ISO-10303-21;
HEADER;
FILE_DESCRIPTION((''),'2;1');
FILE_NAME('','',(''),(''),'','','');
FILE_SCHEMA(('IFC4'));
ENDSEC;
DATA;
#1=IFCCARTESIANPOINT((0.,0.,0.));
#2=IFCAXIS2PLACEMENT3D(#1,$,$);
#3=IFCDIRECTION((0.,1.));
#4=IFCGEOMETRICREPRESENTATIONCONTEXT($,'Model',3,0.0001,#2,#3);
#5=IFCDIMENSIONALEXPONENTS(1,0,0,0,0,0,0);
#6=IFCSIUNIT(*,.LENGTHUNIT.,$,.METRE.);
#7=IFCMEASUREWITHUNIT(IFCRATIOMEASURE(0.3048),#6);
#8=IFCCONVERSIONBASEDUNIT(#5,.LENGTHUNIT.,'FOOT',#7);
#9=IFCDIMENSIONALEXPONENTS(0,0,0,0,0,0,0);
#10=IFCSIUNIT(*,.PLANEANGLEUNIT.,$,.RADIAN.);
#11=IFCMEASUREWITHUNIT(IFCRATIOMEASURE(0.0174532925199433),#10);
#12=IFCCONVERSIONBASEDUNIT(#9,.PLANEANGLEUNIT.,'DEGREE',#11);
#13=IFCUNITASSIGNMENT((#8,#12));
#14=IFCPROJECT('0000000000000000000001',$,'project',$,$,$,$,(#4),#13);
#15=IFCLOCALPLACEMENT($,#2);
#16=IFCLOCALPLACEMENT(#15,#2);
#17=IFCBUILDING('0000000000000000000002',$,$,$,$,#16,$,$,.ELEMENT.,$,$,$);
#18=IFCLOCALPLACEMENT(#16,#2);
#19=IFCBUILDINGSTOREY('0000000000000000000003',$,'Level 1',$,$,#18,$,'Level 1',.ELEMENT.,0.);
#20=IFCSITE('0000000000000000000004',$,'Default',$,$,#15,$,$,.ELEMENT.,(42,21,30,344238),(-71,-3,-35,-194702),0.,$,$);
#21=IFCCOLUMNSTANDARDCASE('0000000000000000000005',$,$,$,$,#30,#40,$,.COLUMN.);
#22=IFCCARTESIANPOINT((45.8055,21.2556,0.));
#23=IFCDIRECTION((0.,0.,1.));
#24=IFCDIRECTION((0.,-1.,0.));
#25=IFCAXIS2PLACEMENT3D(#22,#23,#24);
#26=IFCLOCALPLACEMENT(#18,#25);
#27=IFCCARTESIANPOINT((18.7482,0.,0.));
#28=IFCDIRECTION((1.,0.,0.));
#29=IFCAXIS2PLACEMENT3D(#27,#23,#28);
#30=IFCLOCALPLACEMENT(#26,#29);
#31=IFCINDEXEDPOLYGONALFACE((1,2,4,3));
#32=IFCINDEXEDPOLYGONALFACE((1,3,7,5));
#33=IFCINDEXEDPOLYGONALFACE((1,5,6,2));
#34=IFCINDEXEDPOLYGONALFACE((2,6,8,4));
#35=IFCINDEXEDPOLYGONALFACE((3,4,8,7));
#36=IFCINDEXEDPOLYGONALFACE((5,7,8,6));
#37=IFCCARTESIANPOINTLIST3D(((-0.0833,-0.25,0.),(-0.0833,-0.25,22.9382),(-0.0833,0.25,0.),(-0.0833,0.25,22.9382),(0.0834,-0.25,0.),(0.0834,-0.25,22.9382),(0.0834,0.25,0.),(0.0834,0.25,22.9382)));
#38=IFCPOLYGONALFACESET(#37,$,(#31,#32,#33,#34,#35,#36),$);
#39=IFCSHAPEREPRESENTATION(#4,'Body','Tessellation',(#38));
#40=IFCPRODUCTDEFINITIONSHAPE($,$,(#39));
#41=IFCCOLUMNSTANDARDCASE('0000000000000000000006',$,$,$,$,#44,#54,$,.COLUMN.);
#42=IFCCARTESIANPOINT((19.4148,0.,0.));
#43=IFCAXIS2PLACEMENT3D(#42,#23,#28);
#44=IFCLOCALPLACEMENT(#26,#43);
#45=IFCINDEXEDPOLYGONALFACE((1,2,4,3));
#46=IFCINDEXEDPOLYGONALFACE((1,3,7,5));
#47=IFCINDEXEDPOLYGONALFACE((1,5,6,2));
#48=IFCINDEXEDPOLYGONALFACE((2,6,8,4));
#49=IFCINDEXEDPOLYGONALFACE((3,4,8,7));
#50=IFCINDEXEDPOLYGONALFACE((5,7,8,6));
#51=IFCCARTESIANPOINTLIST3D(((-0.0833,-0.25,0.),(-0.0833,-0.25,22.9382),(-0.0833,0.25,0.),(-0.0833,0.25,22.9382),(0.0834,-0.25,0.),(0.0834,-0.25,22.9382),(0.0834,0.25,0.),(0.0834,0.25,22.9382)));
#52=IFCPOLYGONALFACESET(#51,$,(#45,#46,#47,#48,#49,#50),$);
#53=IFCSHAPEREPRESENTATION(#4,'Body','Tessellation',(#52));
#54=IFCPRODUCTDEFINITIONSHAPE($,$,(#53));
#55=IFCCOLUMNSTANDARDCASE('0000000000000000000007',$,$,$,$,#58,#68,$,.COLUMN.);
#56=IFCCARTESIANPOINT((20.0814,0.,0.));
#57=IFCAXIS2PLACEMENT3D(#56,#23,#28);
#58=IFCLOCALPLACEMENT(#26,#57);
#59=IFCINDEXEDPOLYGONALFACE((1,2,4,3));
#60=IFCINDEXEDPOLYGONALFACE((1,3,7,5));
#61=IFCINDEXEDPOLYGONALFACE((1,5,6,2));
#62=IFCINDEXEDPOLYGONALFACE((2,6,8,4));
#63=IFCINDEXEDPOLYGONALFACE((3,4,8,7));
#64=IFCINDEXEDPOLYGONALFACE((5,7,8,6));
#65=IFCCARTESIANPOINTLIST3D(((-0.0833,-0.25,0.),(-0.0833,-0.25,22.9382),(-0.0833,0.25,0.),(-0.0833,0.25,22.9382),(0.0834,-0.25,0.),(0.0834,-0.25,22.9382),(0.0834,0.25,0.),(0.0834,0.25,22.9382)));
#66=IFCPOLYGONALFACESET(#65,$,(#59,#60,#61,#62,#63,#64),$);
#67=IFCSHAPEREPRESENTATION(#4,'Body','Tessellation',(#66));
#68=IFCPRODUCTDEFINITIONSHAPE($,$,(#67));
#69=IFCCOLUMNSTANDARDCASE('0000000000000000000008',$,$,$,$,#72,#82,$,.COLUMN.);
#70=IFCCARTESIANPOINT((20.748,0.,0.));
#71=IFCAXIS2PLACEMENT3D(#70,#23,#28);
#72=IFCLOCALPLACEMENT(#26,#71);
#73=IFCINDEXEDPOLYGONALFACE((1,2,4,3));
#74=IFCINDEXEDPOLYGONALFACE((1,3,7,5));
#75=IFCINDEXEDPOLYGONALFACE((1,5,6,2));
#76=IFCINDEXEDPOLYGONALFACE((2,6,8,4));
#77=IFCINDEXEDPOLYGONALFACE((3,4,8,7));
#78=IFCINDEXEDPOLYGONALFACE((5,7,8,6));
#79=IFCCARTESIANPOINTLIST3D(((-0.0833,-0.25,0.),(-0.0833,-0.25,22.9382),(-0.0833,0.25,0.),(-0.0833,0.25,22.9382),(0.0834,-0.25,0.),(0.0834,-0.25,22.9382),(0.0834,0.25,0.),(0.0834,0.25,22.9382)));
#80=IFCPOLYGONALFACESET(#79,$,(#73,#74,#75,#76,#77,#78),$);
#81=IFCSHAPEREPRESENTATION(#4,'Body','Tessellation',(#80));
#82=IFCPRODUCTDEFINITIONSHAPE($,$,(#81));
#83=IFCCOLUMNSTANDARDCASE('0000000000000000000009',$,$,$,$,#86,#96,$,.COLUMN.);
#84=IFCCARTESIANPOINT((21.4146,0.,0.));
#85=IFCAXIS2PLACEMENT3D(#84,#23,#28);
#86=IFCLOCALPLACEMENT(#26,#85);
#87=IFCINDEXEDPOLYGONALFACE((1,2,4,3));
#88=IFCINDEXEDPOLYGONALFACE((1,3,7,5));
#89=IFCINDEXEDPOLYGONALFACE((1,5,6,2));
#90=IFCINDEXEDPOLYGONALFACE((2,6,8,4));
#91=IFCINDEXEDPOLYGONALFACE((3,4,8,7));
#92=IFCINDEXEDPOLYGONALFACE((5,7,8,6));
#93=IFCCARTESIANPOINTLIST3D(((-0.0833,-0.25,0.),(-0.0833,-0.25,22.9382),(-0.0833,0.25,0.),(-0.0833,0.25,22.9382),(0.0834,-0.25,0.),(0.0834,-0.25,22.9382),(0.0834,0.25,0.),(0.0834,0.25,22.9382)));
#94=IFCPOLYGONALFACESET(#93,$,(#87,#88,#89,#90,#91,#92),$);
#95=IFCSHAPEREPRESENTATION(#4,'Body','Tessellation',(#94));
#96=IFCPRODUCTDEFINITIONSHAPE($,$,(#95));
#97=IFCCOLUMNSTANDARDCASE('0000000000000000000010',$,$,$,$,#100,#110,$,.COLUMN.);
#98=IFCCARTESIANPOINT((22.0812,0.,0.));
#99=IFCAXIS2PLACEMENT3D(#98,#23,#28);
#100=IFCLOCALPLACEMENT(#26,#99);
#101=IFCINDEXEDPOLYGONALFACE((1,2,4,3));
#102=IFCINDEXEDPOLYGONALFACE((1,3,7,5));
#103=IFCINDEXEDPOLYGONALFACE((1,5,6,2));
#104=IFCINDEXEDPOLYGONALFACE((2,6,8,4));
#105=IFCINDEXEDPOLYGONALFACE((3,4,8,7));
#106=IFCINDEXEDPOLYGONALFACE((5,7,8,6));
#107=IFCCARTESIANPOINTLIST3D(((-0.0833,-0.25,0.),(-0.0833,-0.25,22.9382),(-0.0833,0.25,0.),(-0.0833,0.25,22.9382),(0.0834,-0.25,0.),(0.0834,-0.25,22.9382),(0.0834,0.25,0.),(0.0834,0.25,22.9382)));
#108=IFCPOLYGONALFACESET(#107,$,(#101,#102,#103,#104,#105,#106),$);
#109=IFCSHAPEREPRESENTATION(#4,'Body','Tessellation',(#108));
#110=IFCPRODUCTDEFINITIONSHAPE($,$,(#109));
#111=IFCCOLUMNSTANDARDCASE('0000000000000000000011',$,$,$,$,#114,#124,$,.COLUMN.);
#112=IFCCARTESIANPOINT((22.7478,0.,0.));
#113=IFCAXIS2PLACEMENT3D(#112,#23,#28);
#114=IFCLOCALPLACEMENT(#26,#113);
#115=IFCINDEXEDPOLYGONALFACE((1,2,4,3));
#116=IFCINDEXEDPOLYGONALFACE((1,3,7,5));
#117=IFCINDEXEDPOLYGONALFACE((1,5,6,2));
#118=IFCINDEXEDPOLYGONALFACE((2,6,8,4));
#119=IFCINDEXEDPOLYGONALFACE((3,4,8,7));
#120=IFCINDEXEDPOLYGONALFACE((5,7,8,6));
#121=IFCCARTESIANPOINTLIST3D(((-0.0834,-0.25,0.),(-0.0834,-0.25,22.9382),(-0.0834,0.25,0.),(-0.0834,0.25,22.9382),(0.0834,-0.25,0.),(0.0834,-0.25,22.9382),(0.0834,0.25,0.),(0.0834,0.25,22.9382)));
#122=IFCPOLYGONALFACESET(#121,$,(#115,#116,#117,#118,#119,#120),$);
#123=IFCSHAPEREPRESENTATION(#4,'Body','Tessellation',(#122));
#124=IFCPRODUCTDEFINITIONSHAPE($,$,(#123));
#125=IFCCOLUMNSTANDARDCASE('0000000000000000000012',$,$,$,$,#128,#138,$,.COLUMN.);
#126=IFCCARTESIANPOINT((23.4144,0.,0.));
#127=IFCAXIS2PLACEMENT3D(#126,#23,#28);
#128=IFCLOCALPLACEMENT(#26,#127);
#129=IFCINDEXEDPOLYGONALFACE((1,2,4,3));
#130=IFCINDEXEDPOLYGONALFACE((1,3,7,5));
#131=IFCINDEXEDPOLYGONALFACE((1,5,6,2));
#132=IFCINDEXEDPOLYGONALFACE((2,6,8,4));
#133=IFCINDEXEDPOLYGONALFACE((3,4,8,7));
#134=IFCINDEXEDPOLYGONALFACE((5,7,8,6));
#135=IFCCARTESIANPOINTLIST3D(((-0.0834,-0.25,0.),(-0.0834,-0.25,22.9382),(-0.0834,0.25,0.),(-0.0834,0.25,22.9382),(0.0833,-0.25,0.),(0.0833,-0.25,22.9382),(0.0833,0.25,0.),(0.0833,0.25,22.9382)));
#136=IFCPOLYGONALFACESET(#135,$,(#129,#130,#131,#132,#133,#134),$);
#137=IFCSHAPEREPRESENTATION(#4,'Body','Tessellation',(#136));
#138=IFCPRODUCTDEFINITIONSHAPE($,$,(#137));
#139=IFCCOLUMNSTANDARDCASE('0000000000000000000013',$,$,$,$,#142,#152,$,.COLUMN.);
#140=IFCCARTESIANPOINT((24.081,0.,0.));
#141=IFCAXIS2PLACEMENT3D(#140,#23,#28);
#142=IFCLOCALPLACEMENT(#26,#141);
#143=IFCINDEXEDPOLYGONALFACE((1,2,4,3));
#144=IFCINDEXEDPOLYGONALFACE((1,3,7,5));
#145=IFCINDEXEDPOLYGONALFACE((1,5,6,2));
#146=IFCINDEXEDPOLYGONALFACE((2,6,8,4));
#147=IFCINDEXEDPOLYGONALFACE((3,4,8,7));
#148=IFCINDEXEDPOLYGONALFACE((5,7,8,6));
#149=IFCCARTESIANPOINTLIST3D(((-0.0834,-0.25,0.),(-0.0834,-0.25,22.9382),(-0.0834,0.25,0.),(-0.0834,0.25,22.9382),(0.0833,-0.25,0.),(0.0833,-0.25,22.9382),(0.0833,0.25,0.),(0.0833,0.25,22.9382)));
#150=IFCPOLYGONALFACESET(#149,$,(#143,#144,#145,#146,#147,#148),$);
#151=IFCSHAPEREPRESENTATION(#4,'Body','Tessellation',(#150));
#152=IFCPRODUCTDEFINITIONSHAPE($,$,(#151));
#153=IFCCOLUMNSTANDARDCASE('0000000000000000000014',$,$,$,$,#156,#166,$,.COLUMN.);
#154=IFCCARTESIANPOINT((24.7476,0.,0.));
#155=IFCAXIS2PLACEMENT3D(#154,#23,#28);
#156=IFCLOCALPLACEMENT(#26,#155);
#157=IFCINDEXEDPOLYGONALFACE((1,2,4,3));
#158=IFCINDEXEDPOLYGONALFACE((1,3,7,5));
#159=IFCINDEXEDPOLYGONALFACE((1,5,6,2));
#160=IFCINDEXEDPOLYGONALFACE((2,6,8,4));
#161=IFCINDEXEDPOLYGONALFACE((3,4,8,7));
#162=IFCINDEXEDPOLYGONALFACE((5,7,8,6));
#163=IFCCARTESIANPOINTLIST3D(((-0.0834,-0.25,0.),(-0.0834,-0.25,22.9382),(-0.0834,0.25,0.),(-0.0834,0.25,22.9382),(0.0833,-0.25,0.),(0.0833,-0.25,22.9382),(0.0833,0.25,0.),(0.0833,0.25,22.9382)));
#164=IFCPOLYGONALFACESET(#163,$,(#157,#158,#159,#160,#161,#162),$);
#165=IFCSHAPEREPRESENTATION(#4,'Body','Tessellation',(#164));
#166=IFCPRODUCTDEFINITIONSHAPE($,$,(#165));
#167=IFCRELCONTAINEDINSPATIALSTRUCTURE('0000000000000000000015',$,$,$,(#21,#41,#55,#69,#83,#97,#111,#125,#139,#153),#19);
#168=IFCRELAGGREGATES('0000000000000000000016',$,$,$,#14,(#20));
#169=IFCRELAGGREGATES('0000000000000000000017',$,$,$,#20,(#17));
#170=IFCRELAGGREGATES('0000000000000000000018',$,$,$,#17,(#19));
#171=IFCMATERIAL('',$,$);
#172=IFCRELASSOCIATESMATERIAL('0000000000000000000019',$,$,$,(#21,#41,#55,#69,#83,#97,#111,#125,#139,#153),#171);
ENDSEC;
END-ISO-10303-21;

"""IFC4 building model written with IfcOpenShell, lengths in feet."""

from ifc_helpers import new_model, entity, si_unit, converted_unit, direction, frame, origin, place, context, project, spatial, rectangle, extrude, material, element, save


model = new_model("IFC4")

# Units and contexts
model_context = context("Model", 3, precision=0.0001, world=origin(), true_north=direction((0.0, 1.0)))
ifc_project = project(units=[converted_unit("LENGTHUNIT", "FOOT", entity("IfcRatioMeasure", 0.3048), si_unit("LENGTHUNIT", "METRE"), dimensions=[1, 0, 0, 0, 0, 0, 0]), converted_unit("PLANEANGLEUNIT", "DEGREE", entity("IfcRatioMeasure", 0.0174532925199433), si_unit("PLANEANGLEUNIT", "RADIAN"), dimensions=[0, 0, 0, 0, 0, 0, 0])], contexts=[model_context])

# Site, building, storey
site_placement = place(None, origin())
site = spatial("IfcSite", under=ifc_project, at=site_placement, Name="Default", CompositionType="ELEMENT", RefLatitude=(42, 21, 30, 344238), RefLongitude=(-71, -3, -35, -194702), RefElevation=0.0)
building_placement = place(site_placement, origin())
building = spatial("IfcBuilding", under=site, at=building_placement, CompositionType="ELEMENT")
storey_placement = place(building_placement, origin())
storey = spatial("IfcBuildingStorey", under=building, at=storey_placement, Name="Level 1", LongName="Level 1", CompositionType="ELEMENT", Elevation=0.0)

# Columns
ifc_material = material(Name="")
placement = place(storey_placement, frame((45.8055, 21.2556, 0.0), z_axis=(0.0, 0.0, 1.0), x_axis=(0.0, -1.0, 0.0)))
for number, where, z_axis, x_axis in (
    (1, (18.7482, 0.0, 0.0), (0.0, 0.0, 1.0), (1.0, 0.0, 0.0)),
    (2, (19.4148, 0.0, 0.0), (0.0, 0.0, 1.0), (1.0, 0.0, 0.0)),
    (3, (20.0814, 0.0, 0.0), (0.0, 0.0, 1.0), (1.0, 0.0, 0.0)),
    (4, (20.748, 0.0, 0.0), (0.0, 0.0, 1.0), (1.0, 0.0, 0.0)),
    (5, (21.4146, 0.0, 0.0), (0.0, 0.0, 1.0), (1.0, 0.0, 0.0)),
    (6, (22.0812, 0.0, 0.0), (0.0, 0.0, 1.0), (1.0, 0.0, 0.0)),
    (7, (22.7478, 0.0, 0.0), (0.0, 0.0, 1.0), (1.0, 0.0, 0.0)),
    (8, (23.4144, 0.0, 0.0), (0.0, 0.0, 1.0), (1.0, 0.0, 0.0)),
    (9, (24.081, 0.0, 0.0), (0.0, 0.0, 1.0), (1.0, 0.0, 0.0)),
    (10, (24.7476, 0.0, 0.0), (0.0, 0.0, 1.0), (1.0, 0.0, 0.0)),
):
    element("IfcColumnStandardCase", number, at=place(placement, frame(where, z_axis=z_axis, x_axis=x_axis)), inside=storey, material=ifc_material, PredefinedType="COLUMN", context=model_context, shape_type="SweptSolid", body=[
        extrude(rectangle(XDim=0.1667, YDim=0.5), origin(), (0.0, 0.0, 1.0), 22.9382),
    ])

save(model, "model.ifc")
